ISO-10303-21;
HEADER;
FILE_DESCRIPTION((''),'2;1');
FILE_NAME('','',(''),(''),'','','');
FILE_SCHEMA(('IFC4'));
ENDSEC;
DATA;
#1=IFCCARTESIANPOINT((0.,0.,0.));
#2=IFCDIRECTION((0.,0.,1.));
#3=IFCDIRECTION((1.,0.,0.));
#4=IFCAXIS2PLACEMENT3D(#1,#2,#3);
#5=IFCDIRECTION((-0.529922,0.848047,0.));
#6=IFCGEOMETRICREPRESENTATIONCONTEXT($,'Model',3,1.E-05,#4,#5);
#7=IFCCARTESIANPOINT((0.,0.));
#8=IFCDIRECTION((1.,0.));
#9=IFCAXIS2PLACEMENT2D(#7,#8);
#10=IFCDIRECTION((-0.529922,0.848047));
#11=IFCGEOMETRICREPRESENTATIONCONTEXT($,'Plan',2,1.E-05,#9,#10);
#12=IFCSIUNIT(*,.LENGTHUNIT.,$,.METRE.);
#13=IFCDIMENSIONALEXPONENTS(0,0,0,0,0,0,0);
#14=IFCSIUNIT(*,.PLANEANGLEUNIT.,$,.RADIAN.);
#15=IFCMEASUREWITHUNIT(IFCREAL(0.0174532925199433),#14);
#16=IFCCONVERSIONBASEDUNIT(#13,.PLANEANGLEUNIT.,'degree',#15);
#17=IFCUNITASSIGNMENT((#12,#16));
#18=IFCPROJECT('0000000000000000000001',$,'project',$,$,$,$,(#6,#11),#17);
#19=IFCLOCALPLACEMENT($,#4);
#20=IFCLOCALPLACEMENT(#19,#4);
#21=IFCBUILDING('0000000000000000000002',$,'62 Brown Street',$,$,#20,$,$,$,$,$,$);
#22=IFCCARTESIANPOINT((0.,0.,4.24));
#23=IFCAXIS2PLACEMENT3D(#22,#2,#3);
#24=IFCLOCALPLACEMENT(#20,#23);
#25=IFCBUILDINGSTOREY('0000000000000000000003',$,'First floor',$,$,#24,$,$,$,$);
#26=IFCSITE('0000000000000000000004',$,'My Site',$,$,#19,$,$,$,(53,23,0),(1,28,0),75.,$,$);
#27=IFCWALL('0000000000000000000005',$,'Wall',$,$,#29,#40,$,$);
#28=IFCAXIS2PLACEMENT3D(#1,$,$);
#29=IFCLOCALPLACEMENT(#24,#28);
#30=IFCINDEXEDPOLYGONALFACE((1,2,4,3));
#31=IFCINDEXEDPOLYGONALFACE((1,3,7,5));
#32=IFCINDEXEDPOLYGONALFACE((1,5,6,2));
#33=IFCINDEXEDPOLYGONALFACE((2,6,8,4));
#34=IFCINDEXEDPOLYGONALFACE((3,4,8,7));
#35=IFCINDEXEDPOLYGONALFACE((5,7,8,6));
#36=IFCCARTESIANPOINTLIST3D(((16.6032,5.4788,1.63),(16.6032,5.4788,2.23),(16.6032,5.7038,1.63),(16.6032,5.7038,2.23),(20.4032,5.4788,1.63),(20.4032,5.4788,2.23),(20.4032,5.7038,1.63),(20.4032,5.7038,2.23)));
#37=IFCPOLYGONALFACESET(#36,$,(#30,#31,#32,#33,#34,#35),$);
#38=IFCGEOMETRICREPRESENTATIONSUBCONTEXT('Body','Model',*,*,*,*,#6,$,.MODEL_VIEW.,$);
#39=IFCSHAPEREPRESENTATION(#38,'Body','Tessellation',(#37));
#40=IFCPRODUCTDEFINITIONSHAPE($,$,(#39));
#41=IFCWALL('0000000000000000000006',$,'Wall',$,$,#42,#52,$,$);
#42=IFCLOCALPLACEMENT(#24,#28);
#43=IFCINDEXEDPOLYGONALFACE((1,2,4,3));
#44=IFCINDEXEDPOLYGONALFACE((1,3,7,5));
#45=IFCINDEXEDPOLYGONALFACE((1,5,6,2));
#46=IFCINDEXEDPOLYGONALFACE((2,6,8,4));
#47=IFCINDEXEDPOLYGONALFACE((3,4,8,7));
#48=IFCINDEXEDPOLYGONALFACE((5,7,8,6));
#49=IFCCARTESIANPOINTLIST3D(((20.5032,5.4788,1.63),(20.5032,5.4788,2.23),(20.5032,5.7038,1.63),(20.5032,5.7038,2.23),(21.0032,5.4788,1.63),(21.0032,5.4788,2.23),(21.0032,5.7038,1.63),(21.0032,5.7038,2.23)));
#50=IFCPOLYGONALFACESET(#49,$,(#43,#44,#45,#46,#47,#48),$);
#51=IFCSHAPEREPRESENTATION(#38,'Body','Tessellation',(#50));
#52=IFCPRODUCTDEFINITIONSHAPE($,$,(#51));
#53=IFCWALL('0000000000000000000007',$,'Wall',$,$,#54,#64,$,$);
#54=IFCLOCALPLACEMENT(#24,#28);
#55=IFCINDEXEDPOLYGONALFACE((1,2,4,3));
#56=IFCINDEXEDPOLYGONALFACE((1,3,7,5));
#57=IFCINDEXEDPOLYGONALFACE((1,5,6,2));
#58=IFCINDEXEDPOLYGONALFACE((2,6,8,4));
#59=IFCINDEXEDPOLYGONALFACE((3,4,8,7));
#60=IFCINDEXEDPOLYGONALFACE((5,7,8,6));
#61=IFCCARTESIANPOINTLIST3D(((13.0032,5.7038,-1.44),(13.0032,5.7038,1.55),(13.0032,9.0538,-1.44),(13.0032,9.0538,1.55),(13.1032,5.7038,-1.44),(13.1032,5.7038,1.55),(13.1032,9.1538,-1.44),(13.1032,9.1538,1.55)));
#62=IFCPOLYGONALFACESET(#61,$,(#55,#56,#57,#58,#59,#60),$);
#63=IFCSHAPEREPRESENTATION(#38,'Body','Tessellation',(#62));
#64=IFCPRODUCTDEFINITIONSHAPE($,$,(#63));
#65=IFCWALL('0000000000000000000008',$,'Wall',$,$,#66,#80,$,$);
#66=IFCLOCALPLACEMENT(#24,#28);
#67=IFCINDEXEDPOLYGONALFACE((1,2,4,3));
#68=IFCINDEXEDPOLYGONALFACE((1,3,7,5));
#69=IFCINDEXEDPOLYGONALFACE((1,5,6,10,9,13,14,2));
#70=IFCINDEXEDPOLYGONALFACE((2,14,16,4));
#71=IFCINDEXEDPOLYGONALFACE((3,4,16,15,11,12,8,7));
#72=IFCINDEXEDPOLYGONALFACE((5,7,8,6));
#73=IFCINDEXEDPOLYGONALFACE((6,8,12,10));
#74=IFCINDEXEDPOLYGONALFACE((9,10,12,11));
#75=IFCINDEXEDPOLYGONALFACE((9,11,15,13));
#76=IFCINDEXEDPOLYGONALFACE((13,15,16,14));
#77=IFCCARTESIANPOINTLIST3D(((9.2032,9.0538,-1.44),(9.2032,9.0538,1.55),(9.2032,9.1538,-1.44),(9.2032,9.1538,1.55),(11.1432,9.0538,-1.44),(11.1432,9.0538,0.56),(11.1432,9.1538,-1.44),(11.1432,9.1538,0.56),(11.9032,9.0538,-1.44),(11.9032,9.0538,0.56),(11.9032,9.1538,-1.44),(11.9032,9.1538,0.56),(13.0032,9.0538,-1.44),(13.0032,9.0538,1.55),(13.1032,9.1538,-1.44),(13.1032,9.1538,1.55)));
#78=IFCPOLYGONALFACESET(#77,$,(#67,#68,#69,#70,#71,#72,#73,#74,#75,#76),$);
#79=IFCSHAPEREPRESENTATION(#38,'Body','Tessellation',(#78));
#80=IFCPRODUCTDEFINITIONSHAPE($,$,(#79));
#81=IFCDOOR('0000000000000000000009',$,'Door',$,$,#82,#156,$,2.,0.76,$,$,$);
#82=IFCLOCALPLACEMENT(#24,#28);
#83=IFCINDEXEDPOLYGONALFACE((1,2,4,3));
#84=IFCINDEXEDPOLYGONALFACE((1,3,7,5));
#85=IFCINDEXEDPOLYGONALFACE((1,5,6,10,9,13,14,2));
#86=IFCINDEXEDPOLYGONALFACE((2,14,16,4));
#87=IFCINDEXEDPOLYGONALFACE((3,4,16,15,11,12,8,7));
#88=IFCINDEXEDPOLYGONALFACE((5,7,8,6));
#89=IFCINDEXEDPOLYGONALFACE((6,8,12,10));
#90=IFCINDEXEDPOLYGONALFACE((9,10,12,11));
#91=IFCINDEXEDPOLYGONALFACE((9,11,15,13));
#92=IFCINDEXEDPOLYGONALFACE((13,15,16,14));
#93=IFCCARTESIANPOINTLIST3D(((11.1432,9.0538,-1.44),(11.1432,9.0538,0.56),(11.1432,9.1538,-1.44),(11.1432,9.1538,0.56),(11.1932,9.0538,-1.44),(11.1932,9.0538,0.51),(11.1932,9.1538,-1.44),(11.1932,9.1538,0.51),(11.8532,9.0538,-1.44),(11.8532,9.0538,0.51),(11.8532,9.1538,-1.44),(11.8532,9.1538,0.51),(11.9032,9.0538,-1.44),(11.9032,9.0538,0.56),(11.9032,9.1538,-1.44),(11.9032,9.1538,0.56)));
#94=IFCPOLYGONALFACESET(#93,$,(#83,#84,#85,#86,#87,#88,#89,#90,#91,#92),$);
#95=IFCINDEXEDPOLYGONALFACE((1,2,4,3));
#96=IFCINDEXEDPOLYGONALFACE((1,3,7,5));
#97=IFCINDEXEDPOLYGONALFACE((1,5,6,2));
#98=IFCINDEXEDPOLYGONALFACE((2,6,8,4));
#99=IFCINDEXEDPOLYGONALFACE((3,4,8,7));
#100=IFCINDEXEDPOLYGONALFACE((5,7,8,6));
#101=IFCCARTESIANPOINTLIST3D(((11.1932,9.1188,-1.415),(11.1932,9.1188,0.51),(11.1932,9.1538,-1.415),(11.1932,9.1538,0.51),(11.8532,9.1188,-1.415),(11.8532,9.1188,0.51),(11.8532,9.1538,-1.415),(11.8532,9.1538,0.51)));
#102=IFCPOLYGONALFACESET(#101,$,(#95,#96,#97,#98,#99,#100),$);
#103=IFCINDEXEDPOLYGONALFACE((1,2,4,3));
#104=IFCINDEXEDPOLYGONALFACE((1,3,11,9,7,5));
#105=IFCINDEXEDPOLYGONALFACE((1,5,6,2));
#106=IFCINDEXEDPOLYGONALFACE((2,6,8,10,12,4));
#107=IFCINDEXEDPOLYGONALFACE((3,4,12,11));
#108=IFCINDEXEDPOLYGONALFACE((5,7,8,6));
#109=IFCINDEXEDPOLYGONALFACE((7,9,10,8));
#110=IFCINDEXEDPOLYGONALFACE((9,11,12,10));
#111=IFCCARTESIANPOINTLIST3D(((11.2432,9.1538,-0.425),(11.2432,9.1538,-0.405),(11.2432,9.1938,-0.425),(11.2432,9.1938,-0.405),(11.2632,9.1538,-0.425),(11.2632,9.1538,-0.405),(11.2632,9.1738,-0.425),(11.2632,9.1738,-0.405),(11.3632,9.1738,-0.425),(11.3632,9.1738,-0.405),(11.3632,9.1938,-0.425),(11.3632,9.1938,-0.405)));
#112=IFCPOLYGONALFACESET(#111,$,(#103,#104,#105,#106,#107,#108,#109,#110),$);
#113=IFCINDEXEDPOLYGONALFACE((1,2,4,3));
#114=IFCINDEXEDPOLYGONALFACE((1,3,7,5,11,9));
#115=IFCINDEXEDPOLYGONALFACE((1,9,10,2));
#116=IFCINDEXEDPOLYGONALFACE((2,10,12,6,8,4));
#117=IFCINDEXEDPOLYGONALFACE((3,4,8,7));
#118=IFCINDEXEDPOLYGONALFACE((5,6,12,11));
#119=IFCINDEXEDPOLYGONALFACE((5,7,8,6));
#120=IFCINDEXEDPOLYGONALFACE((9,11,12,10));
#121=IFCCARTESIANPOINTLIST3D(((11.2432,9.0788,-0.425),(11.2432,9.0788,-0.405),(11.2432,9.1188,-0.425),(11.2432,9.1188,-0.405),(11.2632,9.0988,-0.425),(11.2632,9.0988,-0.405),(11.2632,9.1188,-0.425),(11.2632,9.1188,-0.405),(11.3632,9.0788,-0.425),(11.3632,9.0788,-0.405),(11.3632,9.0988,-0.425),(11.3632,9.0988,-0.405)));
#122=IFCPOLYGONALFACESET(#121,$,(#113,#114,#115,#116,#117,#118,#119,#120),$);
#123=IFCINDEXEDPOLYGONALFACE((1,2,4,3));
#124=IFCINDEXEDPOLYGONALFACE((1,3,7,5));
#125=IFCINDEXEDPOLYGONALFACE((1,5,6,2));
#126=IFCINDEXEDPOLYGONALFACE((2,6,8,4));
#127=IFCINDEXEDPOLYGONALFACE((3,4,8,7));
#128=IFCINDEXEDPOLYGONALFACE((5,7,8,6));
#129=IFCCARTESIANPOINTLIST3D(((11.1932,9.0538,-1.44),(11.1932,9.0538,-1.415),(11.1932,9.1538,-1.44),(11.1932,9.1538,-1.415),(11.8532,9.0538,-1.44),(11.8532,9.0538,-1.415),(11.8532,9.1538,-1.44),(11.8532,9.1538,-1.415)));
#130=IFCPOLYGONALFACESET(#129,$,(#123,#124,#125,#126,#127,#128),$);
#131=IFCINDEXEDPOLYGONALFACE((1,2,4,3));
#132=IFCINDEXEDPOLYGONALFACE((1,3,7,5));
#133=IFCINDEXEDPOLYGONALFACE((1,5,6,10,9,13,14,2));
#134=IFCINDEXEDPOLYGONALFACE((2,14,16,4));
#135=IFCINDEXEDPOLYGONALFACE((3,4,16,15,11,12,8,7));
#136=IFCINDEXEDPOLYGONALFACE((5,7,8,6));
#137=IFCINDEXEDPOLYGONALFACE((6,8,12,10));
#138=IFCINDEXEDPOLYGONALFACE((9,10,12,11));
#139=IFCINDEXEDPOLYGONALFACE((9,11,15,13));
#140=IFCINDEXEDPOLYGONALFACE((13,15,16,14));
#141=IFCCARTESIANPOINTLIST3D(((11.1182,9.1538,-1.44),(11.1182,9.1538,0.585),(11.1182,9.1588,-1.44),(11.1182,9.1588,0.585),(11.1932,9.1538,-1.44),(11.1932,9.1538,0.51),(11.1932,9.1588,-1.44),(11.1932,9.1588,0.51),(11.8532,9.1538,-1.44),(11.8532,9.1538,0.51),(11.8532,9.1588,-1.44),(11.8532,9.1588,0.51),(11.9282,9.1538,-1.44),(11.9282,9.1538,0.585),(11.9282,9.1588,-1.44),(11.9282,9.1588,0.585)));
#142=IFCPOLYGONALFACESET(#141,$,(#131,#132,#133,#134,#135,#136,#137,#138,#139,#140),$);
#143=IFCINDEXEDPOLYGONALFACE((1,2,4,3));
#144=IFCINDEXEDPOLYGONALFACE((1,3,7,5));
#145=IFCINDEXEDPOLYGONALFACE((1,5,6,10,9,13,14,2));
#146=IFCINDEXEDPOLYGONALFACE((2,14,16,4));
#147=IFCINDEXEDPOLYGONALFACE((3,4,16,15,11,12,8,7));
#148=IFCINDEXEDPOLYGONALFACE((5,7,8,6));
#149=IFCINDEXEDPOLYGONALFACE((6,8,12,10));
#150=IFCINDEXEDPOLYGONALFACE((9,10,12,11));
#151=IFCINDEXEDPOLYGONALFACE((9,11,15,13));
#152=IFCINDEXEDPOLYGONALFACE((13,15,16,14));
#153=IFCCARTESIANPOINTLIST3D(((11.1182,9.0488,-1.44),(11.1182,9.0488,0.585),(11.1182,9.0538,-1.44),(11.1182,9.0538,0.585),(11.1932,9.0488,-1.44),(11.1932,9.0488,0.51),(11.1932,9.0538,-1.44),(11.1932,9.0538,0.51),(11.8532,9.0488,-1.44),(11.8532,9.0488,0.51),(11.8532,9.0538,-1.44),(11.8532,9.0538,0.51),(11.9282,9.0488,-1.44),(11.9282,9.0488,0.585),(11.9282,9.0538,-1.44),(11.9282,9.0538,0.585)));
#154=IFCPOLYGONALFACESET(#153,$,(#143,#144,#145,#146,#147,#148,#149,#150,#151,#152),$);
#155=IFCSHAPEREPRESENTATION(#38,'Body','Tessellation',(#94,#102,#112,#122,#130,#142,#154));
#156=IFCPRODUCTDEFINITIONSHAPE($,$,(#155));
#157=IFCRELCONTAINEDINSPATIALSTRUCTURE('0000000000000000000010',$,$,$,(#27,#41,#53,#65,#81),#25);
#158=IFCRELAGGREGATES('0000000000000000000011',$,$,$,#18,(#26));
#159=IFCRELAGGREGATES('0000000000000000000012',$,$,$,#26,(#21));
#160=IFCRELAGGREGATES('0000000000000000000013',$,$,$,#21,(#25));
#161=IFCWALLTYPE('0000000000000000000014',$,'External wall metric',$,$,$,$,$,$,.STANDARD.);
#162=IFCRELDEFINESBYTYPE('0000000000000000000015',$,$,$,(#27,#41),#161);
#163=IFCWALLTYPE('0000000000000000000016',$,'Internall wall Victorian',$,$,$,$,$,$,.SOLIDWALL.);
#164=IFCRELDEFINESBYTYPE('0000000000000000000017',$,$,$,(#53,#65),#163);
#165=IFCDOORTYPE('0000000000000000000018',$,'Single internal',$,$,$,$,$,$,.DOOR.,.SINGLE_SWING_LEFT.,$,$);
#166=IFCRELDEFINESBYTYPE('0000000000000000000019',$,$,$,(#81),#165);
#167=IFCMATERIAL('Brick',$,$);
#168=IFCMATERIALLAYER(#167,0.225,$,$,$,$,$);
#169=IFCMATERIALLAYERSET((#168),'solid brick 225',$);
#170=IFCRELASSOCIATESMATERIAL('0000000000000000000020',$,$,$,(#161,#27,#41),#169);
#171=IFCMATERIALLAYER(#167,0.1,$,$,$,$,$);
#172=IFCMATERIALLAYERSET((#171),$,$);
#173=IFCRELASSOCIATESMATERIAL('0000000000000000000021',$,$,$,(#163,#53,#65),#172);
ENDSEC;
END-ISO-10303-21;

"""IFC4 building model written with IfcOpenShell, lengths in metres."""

from ifc_helpers import new_model, entity, si_unit, converted_unit, direction, frame, origin_with_axes, origin_2d_with_axis, place, context, subcontext, project, spatial, line, indexed_curve, outline, extrude, clip, halfspace, shape, source, transform, mapped, material, layer, layer_set, layer_usage, type_object, type_shapes, element, fill, save


model = new_model("IFC4")

# Units and contexts
model_context = context("Model", 3, precision=1e-05, world=origin_with_axes(), true_north=direction((-0.529922, 0.848047, 0.0)))
plan_context = context("Plan", 2, precision=1e-05, world=origin_2d_with_axis(), true_north=direction((-0.529922, 0.848047)))
body_context_1 = subcontext(model_context, "Body", "Model", "MODEL_VIEW")
body_context_2 = subcontext(plan_context, "Body", "Plan", "PLAN_VIEW")
ifc_project = project(units=[si_unit("LENGTHUNIT", "METRE"), converted_unit("PLANEANGLEUNIT", "degree", entity("IfcReal", 0.0174532925199433), si_unit("PLANEANGLEUNIT", "RADIAN"), dimensions=[0, 0, 0, 0, 0, 0, 0])], contexts=[model_context, plan_context])

# Site, building, storey
site_placement = place(None, origin_with_axes())
site = spatial("IfcSite", under=ifc_project, at=site_placement, Name="My Site", RefLatitude=(53, 23, 0), RefLongitude=(1, 28, 0), RefElevation=75.0)
building_placement = place(site_placement, origin_with_axes())
building = spatial("IfcBuilding", under=site, at=building_placement, Name="62 Brown Street")
storey_placement = place(building_placement, frame((0.0, 0.0, 4.24), z_axis=(0.0, 0.0, 1.0), x_axis=(1.0, 0.0, 0.0)))
storey = spatial("IfcBuildingStorey", under=building, at=storey_placement, Name="First floor")

# Walls
ifc_material_1 = material(Name="Brick")
ifc_layer_1 = layer(ifc_material_1, 0.225)
ifc_layer_set_1 = layer_set([ifc_layer_1], Name="solid brick 225")
wall_type_1 = type_object("IfcWallType", Name="External wall metric", PredefinedType="STANDARD", material=ifc_layer_set_1)
ifc_layer_usage_1 = layer_usage(ifc_layer_set_1, "AXIS2", "POSITIVE", 0.0)
wall_1_placement = place(storey_placement, frame((16.6032, 5.4788, 1.63), z_axis=(0.0, 0.0, 1.0), x_axis=(1.0, 0.0, 0.0)))
element("IfcWall", 1, at=wall_1_placement, inside=storey, type_object=wall_type_1, material=ifc_layer_usage_1, Name="Wall", context=body_context_1, shape_type="SweptSolid", body=[
    extrude(outline(indexed_curve([(0.0, 0.0), (0.0, 0.225), (3.8, 0.225), (3.8, 0.0), (0.0, 0.0)], self_intersect=False)), origin_with_axes(), (0.0, 0.0, 1.0), 0.6),
])
ifc_layer_usage_2 = layer_usage(ifc_layer_set_1, "AXIS2", "POSITIVE", 0.0)
wall_2_placement = place(storey_placement, frame((20.5032, 5.4788, 1.63), z_axis=(0.0, 0.0, 1.0), x_axis=(1.0, 0.0, 0.0)))
element("IfcWall", 2, at=wall_2_placement, inside=storey, type_object=wall_type_1, material=ifc_layer_usage_2, Name="Wall", context=body_context_1, shape_type="SweptSolid", body=[
    extrude(outline(indexed_curve([(0.0, 0.0), (0.0, 0.225), (0.5, 0.225), (0.5, 0.0), (0.0, 0.0)], self_intersect=False)), origin_with_axes(), (0.0, 0.0, 1.0), 0.6),
])
ifc_layer_2 = layer(ifc_material_1, 0.1)
ifc_layer_set_2 = layer_set([ifc_layer_2])
ifc_layer_usage_3 = layer_usage(ifc_layer_set_2, "AXIS2", "POSITIVE", 0.0)
wall_type_2 = type_object("IfcWallType", Name="Internall wall Victorian", PredefinedType="SOLIDWALL", material=ifc_layer_set_2)
wall_3_placement = place(storey_placement, frame((13.1032, 5.7038, -1.44), z_axis=(0.0, 0.0, 1.0), x_axis=(0.0, 1.0, 0.0)))
element("IfcWall", 3, at=wall_3_placement, inside=storey, type_object=wall_type_2, material=ifc_layer_usage_3, Name="Wall", context=body_context_1, shape_type="Clipping", body=[
    clip(extrude(outline(indexed_curve([(0.0, 0.0), (0.0, 0.1), (3.45, 0.1), (3.45, 0.0), (0.0, 0.0)], self_intersect=False)), origin_with_axes(), (0.0, 0.0, 1.0), 2.99), halfspace(frame((3.45, 0.0, -2.8), z_axis=(0.70711, 0.707104, 0.0), x_axis=(0.707104, -0.70711, 0.0)), False)),
])

# Wall, opening, door
ifc_layer_usage_4 = layer_usage(ifc_layer_set_2, "AXIS2", "POSITIVE", 0.0)
wall_4_placement = place(storey_placement, frame((13.1032, 9.1538, -1.44), z_axis=(0.0, 0.0, 1.0), x_axis=(-1.0, 0.0, 0.0)))
wall_4 = element("IfcWall", 4, at=wall_4_placement, inside=storey, type_object=wall_type_2, material=ifc_layer_usage_4, Name="Wall", context=body_context_1, shape_type="Clipping", body=[
    clip(extrude(outline(indexed_curve([(0.0, 0.0), (0.0, 0.1), (3.9, 0.1), (3.9, 0.0), (0.0, 0.0)], self_intersect=False)), origin_with_axes(), (0.0, 0.0, 1.0), 2.99), halfspace(frame((0.0, 0.0, -2.8), z_axis=(-0.707104, 0.70711, 0.0), x_axis=(0.70711, 0.707104, 0.0)), False)),
])
shared_shape_1 = source(origin_with_axes(), body_context_1, "Body", "SweptSolid", [
    extrude(outline(indexed_curve([(0.0, 0.0), (0.76, 0.0), (0.76, 2.0), (0.0, 2.0)], segments=[line(1, 2, 3, 4, 1)])), frame((0.0, -0.6, 0.0), z_axis=(0.0, -1.0, 0.0), x_axis=(1.0, 0.0, 0.0)), (0.0, 0.0, -1.0), 1.2),
])
opening_placement = place(wall_4_placement, frame((1.2, 0.0, 0.0), z_axis=(0.0, 0.0, 1.0), x_axis=(1.0, 0.0, 0.0)))
opening = element("IfcOpeningElement", 5, at=opening_placement, cuts=wall_4, PredefinedType="OPENING", context=body_context_1, shape_type="MappedRepresentation", body=[
    mapped(shared_shape_1, transform((0.0, 0.0, 0.0), x_axis=(1.0, 0.0, 0.0), y_axis=(0.0, 1.0, 0.0), z_axis=(0.0, 0.0, 1.0), scale=1.0)),
])
door_type = type_object("IfcDoorType", Name="Single internal", OperationType="SINGLE_SWING_LEFT", PredefinedType="DOOR")
shared_shape_2 = source(origin_with_axes(), body_context_1, "Body", "SweptSolid", [
    extrude(outline(indexed_curve([(0.0, 0.0), (0.0, 2.0), (0.76, 2.0), (0.76, 0.0), (0.71, 0.0), (0.71, 1.95), (0.05, 1.95), (0.05, 0.0)], segments=[line(1, 2, 3, 4, 5, 6, 7, 8, 1)])), frame((0.0, 0.0, 0.0), z_axis=(0.0, -1.0, 0.0), x_axis=(1.0, 0.0, 0.0)), (0.0, 0.0, -1.0), 0.1),
    extrude(outline(indexed_curve([(0.0, 0.0), (0.66, 0.0), (0.66, 0.035), (0.0, 0.035)], segments=[line(1, 2, 3, 4, 1)])), frame((0.05, 0.0, 0.025), z_axis=(0.0, 0.0, 1.0), x_axis=(1.0, 0.0, 0.0)), (0.0, 0.0, 1.0), 1.925),
    extrude(outline(indexed_curve([(0.0, 0.0), (0.0, -0.04), (-0.12, -0.04), (-0.12, -0.02), (-0.02, -0.02), (-0.02, 0.0)], segments=[line(1, 2, 3, 4, 5, 6, 1)])), frame((0.66, 0.0, 1.015), z_axis=(0.0, 0.0, 1.0), x_axis=(1.0, 0.0, 0.0)), (0.0, 0.0, 1.0), 0.02),
    extrude(outline(indexed_curve([(0.0, 0.0), (0.0, 0.04), (-0.12, 0.04), (-0.12, 0.02), (-0.02, 0.02), (-0.02, 0.0)], segments=[line(1, 2, 3, 4, 5, 6, 1)])), frame((0.66, 0.035, 1.015), z_axis=(0.0, 0.0, 1.0), x_axis=(1.0, 0.0, 0.0)), (0.0, 0.0, 1.0), 0.02),
    extrude(outline(indexed_curve([(0.0, 0.0), (0.66, 0.0), (0.66, 0.1), (0.0, 0.1)], segments=[line(1, 2, 3, 4, 1)])), frame((0.05, 0.0, 0.0), z_axis=(0.0, 0.0, 1.0), x_axis=(1.0, 0.0, 0.0)), (0.0, 0.0, 1.0), 0.025),
    extrude(outline(indexed_curve([(0.0, 0.0), (0.0, 2.025), (0.81, 2.025), (0.81, 0.0), (0.735, 0.0), (0.735, 1.95), (0.075, 1.95), (0.075, 0.0)], segments=[line(1, 2, 3, 4, 5, 6, 7, 8, 1)])), frame((-0.025, -0.005, 0.0), z_axis=(0.0, -1.0, 0.0), x_axis=(1.0, 0.0, 0.0)), (0.0, 0.0, -1.0), 0.005),
    extrude(outline(indexed_curve([(0.0, 0.0), (0.0, 2.025), (0.81, 2.025), (0.81, 0.0), (0.735, 0.0), (0.735, 1.95), (0.075, 1.95), (0.075, 0.0)], segments=[line(1, 2, 3, 4, 5, 6, 7, 8, 1)])), frame((-0.025, 0.1, 0.0), z_axis=(0.0, -1.0, 0.0), x_axis=(1.0, 0.0, 0.0)), (0.0, 0.0, -1.0), 0.005),
])
shared_shape_3 = source(origin_with_axes(), body_context_2, "Body", "Curve2D", [
    entity("IfcIndexedPolyCurve", entity("IfcCartesianPointList2D", [[0.0, 0.0], [0.05, 0.0], [0.05, 0.1], [0.0, 0.1]]), [entity("IfcLineIndex", [1, 2, 3, 4, 1])]),
    entity("IfcIndexedPolyCurve", entity("IfcCartesianPointList2D", [[0.76, 0.0], [0.71, 0.0], [0.71, 0.1], [0.76, 0.1]]), [entity("IfcLineIndex", [1, 2, 3, 4, 1])]),
    entity("IfcTrimmedCurve", entity("IfcEllipse", entity("IfcAxis2Placement2D", entity("IfcCartesianPoint", [0.085, 0.1]), entity("IfcDirection", [1.0, 0.0])), 0.625, 0.66), [entity("IfcCartesianPoint", [0.71, 0.1])], [entity("IfcCartesianPoint", [0.085, 0.76])], True, "CARTESIAN"),
    entity("IfcIndexedPolyCurve", entity("IfcCartesianPointList2D", [[0.05, 0.1], [0.085, 0.1], [0.085, 0.76], [0.05, 0.76]]), [entity("IfcLineIndex", [1, 2, 3, 4, 1])]),
])
type_shapes(door_type, [shared_shape_2, shared_shape_3])
door_placement = place(opening_placement, frame((0.0, 0.0, 0.0), z_axis=(0.0, 0.0, 1.0), x_axis=(1.0, 0.0, 0.0)))
door = element("IfcDoor", 6, at=door_placement, inside=storey, type_object=door_type, Name="Door", OverallHeight=2.0, OverallWidth=0.76, shapes=[
    shape(body_context_1, "Body", "MappedRepresentation", [mapped(shared_shape_2, transform((0.0, 0.0, 0.0), x_axis=(1.0, 0.0, 0.0), y_axis=(0.0, 1.0, 0.0), z_axis=(0.0, 0.0, 1.0), scale=1.0))]),
    shape(body_context_2, "Body", "MappedRepresentation", [mapped(shared_shape_3, transform((0.0, 0.0, 0.0), x_axis=(1.0, 0.0, 0.0), y_axis=(0.0, 1.0, 0.0), z_axis=(0.0, 0.0, 1.0), scale=1.0))]),
])
fill(opening, door)

save(model, "model.ifc")
